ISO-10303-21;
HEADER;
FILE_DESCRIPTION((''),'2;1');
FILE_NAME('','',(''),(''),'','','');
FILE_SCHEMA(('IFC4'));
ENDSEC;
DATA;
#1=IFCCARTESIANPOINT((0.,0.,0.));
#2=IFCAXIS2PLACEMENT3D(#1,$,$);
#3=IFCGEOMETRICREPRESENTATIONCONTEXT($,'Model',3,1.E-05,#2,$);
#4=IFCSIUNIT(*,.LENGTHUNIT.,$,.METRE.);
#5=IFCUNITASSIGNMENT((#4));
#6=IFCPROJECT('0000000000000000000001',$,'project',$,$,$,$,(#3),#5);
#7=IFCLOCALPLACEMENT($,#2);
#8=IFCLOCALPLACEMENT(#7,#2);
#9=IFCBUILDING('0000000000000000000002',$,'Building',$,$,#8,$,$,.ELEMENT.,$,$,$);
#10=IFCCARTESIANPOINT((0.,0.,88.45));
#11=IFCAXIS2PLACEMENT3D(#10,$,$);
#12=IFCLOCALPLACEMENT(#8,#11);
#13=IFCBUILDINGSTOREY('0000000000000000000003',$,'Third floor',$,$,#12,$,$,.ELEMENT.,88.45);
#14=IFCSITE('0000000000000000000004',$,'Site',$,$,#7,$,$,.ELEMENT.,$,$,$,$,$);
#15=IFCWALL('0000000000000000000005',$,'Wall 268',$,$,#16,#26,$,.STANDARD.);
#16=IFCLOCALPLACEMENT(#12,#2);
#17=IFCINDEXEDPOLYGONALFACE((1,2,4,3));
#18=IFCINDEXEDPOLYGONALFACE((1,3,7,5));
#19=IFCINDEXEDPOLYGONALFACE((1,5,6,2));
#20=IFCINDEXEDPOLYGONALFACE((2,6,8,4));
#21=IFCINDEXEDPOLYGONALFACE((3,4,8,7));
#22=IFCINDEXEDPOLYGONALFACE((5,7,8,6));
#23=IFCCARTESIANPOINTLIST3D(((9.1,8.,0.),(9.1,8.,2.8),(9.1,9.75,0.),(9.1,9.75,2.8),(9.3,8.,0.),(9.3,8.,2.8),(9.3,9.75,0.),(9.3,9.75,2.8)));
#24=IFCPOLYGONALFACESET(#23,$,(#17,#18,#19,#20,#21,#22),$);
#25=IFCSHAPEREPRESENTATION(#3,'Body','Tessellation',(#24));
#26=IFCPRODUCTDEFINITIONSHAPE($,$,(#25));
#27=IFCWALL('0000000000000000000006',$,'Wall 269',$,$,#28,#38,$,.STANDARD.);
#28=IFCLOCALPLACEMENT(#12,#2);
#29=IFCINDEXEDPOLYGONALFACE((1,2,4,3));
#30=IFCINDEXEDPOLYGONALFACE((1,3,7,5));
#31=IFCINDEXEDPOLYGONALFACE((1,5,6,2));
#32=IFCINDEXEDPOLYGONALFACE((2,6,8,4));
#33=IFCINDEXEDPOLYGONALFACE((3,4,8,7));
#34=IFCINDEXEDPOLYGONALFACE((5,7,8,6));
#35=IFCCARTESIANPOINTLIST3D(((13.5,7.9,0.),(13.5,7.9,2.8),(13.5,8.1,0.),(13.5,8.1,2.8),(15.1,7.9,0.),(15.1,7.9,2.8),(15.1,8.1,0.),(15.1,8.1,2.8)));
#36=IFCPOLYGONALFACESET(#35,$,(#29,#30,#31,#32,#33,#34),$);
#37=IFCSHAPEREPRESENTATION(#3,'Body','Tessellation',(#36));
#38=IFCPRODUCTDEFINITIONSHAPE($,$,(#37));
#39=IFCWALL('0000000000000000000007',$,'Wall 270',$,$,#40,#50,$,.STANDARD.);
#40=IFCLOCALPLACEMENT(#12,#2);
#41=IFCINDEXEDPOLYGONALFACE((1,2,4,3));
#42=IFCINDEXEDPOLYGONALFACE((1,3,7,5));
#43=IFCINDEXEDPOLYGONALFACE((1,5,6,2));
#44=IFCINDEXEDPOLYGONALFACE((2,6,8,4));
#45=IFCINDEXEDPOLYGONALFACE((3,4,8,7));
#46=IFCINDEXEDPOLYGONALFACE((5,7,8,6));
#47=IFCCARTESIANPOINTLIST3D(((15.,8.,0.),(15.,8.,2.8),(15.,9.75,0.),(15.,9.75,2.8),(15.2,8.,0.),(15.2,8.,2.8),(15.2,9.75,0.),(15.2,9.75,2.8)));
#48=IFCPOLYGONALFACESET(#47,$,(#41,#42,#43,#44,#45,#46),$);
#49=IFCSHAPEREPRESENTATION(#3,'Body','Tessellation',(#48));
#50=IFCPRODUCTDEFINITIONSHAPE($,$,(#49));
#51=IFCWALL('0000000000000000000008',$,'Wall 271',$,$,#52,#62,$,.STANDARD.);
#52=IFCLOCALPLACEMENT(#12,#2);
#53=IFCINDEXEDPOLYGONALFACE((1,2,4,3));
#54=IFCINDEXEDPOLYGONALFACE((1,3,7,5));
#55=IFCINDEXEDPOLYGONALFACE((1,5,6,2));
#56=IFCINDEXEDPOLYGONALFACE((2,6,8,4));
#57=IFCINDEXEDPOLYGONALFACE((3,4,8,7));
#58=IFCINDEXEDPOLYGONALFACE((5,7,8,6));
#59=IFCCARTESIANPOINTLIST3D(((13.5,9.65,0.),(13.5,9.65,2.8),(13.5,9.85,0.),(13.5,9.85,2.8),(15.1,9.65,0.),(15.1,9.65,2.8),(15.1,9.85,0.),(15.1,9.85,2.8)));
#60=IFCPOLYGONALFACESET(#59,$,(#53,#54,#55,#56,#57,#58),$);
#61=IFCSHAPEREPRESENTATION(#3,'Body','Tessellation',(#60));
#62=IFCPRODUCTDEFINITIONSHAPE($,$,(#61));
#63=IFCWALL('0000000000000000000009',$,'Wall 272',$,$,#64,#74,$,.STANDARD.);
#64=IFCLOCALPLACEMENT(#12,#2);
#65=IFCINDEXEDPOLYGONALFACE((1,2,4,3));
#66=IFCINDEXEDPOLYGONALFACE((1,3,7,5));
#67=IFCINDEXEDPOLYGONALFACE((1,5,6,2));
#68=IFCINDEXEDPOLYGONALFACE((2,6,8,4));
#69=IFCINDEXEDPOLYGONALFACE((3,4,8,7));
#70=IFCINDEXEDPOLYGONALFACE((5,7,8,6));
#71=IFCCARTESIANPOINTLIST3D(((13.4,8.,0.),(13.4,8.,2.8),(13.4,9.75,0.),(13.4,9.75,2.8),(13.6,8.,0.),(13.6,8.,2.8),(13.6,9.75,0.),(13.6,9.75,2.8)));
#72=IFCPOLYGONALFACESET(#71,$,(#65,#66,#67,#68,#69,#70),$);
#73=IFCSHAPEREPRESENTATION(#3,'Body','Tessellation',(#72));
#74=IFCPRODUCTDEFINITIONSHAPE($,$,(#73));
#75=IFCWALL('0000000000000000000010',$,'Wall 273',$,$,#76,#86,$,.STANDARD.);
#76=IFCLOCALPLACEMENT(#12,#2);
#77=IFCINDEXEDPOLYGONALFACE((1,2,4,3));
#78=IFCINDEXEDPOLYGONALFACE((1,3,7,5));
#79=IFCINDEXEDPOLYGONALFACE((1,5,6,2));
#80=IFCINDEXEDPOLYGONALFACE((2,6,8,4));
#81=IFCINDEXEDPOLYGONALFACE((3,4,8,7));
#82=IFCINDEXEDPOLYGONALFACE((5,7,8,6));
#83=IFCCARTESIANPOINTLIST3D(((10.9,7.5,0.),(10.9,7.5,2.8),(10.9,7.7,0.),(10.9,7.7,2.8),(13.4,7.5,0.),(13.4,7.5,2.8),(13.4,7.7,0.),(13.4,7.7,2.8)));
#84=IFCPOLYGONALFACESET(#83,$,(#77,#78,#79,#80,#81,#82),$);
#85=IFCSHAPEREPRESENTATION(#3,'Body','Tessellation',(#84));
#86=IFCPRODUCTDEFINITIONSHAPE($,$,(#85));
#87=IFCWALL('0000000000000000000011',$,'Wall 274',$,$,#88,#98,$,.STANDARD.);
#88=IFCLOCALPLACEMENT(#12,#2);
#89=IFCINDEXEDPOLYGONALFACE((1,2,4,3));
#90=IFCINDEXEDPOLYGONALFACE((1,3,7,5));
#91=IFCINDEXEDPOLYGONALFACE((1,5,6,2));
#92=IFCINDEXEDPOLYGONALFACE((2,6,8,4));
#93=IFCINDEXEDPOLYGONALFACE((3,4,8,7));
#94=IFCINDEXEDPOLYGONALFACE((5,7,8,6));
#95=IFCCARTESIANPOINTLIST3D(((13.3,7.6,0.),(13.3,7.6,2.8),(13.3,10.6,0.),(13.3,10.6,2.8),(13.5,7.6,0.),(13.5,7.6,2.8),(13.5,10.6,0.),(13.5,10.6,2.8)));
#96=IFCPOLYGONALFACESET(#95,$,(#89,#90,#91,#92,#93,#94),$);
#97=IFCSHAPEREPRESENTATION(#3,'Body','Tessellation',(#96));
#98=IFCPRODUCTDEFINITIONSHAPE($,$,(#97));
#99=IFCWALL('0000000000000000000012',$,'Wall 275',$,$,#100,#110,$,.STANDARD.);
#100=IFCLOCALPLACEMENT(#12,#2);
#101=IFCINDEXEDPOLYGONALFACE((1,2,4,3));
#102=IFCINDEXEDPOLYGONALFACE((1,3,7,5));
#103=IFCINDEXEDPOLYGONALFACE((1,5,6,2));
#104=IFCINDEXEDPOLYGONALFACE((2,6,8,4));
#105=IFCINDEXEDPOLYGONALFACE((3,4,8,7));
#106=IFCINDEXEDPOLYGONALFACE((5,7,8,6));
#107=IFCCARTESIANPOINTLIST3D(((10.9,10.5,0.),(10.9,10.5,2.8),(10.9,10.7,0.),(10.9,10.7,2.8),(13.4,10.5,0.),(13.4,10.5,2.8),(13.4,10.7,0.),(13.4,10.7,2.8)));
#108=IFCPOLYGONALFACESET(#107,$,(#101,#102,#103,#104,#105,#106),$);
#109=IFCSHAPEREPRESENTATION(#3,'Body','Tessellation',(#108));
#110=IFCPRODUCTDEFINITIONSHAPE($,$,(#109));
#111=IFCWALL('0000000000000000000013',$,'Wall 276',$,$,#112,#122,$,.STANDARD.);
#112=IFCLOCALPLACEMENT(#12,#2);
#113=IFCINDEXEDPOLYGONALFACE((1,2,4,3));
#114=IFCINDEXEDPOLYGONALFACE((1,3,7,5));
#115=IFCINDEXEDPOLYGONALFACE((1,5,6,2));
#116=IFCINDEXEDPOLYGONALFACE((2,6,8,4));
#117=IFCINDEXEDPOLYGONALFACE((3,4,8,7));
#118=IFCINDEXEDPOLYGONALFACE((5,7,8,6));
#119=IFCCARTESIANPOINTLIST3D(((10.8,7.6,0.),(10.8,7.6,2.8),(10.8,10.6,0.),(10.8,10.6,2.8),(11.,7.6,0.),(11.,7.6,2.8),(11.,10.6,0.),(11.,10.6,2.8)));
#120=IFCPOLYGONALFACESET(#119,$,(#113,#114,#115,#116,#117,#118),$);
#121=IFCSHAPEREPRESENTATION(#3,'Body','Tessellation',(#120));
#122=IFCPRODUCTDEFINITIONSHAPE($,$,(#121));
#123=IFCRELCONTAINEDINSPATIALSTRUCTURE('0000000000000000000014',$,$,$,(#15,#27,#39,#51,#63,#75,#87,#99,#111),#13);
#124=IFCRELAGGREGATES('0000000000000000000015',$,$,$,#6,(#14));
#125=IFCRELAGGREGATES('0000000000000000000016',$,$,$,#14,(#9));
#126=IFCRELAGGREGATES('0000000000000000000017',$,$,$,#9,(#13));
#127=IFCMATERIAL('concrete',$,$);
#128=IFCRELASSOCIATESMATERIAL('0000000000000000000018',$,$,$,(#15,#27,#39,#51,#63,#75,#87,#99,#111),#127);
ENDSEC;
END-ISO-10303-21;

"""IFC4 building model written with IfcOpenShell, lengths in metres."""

from ifc_helpers import new_model, si_unit, frame, frame_2d, origin, place, context, project, spatial, rectangle, extrude, material, element, save


model = new_model("IFC4")

# Units and contexts
model_context = context("Model", 3, precision=1e-05, world=origin())
ifc_project = project(units=[si_unit("LENGTHUNIT", "METRE")], contexts=[model_context])

# Site, building, storey
site_placement = place(None, origin())
site = spatial("IfcSite", under=ifc_project, at=site_placement, Name="Site", CompositionType="ELEMENT")
building_placement = place(site_placement, origin())
building = spatial("IfcBuilding", under=site, at=building_placement, Name="Building", CompositionType="ELEMENT")
storey_placement = place(building_placement, frame((0.0, 0.0, 88.45)))
storey = spatial("IfcBuildingStorey", under=building, at=storey_placement, Name="Third floor", CompositionType="ELEMENT", Elevation=88.45)

# Shared definitions
ifc_material = material(Name="concrete")

# Walls
wall_1_placement = place(storey_placement, frame((9.2, 9.75, 0.0), z_axis=(0.0, 0.0, 1.0), x_axis=(0.0, -1.0, 0.0)))
element("IfcWall", 1, at=wall_1_placement, inside=storey, material=ifc_material, Name="Wall 268", PredefinedType="STANDARD", context=model_context, shape_type="SweptSolid", body=[
    extrude(rectangle(XDim=1.75, YDim=0.2, at=frame_2d((0.875, 0.0))), origin(), (0.0, 0.0, 1.0), 2.8),
])
wall_2_placement = place(storey_placement, frame((13.5, 8.0, 0.0), z_axis=(0.0, 0.0, 1.0), x_axis=(1.0, 0.0, 0.0)))
element("IfcWall", 2, at=wall_2_placement, inside=storey, material=ifc_material, Name="Wall 269", PredefinedType="STANDARD", context=model_context, shape_type="SweptSolid", body=[
    extrude(rectangle(XDim=1.6, YDim=0.2, at=frame_2d((0.8, 0.0))), origin(), (0.0, 0.0, 1.0), 2.8),
])
wall_3_placement = place(storey_placement, frame((15.1, 8.0, 0.0), z_axis=(0.0, 0.0, 1.0), x_axis=(0.0, 1.0, 0.0)))
element("IfcWall", 3, at=wall_3_placement, inside=storey, material=ifc_material, Name="Wall 270", PredefinedType="STANDARD", context=model_context, shape_type="SweptSolid", body=[
    extrude(rectangle(XDim=1.75, YDim=0.2, at=frame_2d((0.875, 0.0))), origin(), (0.0, 0.0, 1.0), 2.8),
])
wall_4_placement = place(storey_placement, frame((15.1, 9.75, 0.0), z_axis=(0.0, 0.0, 1.0), x_axis=(-1.0, 0.0, 0.0)))
element("IfcWall", 4, at=wall_4_placement, inside=storey, material=ifc_material, Name="Wall 271", PredefinedType="STANDARD", context=model_context, shape_type="SweptSolid", body=[
    extrude(rectangle(XDim=1.6, YDim=0.2, at=frame_2d((0.8, 0.0))), origin(), (0.0, 0.0, 1.0), 2.8),
])
wall_5_placement = place(storey_placement, frame((13.5, 9.75, 0.0), z_axis=(0.0, 0.0, 1.0), x_axis=(0.0, -1.0, 0.0)))
element("IfcWall", 5, at=wall_5_placement, inside=storey, material=ifc_material, Name="Wall 272", PredefinedType="STANDARD", context=model_context, shape_type="SweptSolid", body=[
    extrude(rectangle(XDim=1.75, YDim=0.2, at=frame_2d((0.875, 0.0))), origin(), (0.0, 0.0, 1.0), 2.8),
])
wall_6_placement = place(storey_placement, frame((10.9, 7.6, 0.0), z_axis=(0.0, 0.0, 1.0), x_axis=(1.0, 0.0, 0.0)))
element("IfcWall", 6, at=wall_6_placement, inside=storey, material=ifc_material, Name="Wall 273", PredefinedType="STANDARD", context=model_context, shape_type="SweptSolid", body=[
    extrude(rectangle(XDim=2.5, YDim=0.2, at=frame_2d((1.25, 0.0))), origin(), (0.0, 0.0, 1.0), 2.8),
])
wall_7_placement = place(storey_placement, frame((13.4, 7.6, 0.0), z_axis=(0.0, 0.0, 1.0), x_axis=(0.0, 1.0, 0.0)))
element("IfcWall", 7, at=wall_7_placement, inside=storey, material=ifc_material, Name="Wall 274", PredefinedType="STANDARD", context=model_context, shape_type="SweptSolid", body=[
    extrude(rectangle(XDim=3.0, YDim=0.2, at=frame_2d((1.5, 0.0))), origin(), (0.0, 0.0, 1.0), 2.8),
])
wall_8_placement = place(storey_placement, frame((13.4, 10.6, 0.0), z_axis=(0.0, 0.0, 1.0), x_axis=(-1.0, 0.0, 0.0)))
element("IfcWall", 8, at=wall_8_placement, inside=storey, material=ifc_material, Name="Wall 275", PredefinedType="STANDARD", context=model_context, shape_type="SweptSolid", body=[
    extrude(rectangle(XDim=2.5, YDim=0.2, at=frame_2d((1.25, 0.0))), origin(), (0.0, 0.0, 1.0), 2.8),
])
wall_9_placement = place(storey_placement, frame((10.9, 10.6, 0.0), z_axis=(0.0, 0.0, 1.0), x_axis=(0.0, -1.0, 0.0)))
element("IfcWall", 9, at=wall_9_placement, inside=storey, material=ifc_material, Name="Wall 276", PredefinedType="STANDARD", context=model_context, shape_type="SweptSolid", body=[
    extrude(rectangle(XDim=3.0, YDim=0.2, at=frame_2d((1.5, 0.0))), origin(), (0.0, 0.0, 1.0), 2.8),
])

save(model, "model.ifc")
